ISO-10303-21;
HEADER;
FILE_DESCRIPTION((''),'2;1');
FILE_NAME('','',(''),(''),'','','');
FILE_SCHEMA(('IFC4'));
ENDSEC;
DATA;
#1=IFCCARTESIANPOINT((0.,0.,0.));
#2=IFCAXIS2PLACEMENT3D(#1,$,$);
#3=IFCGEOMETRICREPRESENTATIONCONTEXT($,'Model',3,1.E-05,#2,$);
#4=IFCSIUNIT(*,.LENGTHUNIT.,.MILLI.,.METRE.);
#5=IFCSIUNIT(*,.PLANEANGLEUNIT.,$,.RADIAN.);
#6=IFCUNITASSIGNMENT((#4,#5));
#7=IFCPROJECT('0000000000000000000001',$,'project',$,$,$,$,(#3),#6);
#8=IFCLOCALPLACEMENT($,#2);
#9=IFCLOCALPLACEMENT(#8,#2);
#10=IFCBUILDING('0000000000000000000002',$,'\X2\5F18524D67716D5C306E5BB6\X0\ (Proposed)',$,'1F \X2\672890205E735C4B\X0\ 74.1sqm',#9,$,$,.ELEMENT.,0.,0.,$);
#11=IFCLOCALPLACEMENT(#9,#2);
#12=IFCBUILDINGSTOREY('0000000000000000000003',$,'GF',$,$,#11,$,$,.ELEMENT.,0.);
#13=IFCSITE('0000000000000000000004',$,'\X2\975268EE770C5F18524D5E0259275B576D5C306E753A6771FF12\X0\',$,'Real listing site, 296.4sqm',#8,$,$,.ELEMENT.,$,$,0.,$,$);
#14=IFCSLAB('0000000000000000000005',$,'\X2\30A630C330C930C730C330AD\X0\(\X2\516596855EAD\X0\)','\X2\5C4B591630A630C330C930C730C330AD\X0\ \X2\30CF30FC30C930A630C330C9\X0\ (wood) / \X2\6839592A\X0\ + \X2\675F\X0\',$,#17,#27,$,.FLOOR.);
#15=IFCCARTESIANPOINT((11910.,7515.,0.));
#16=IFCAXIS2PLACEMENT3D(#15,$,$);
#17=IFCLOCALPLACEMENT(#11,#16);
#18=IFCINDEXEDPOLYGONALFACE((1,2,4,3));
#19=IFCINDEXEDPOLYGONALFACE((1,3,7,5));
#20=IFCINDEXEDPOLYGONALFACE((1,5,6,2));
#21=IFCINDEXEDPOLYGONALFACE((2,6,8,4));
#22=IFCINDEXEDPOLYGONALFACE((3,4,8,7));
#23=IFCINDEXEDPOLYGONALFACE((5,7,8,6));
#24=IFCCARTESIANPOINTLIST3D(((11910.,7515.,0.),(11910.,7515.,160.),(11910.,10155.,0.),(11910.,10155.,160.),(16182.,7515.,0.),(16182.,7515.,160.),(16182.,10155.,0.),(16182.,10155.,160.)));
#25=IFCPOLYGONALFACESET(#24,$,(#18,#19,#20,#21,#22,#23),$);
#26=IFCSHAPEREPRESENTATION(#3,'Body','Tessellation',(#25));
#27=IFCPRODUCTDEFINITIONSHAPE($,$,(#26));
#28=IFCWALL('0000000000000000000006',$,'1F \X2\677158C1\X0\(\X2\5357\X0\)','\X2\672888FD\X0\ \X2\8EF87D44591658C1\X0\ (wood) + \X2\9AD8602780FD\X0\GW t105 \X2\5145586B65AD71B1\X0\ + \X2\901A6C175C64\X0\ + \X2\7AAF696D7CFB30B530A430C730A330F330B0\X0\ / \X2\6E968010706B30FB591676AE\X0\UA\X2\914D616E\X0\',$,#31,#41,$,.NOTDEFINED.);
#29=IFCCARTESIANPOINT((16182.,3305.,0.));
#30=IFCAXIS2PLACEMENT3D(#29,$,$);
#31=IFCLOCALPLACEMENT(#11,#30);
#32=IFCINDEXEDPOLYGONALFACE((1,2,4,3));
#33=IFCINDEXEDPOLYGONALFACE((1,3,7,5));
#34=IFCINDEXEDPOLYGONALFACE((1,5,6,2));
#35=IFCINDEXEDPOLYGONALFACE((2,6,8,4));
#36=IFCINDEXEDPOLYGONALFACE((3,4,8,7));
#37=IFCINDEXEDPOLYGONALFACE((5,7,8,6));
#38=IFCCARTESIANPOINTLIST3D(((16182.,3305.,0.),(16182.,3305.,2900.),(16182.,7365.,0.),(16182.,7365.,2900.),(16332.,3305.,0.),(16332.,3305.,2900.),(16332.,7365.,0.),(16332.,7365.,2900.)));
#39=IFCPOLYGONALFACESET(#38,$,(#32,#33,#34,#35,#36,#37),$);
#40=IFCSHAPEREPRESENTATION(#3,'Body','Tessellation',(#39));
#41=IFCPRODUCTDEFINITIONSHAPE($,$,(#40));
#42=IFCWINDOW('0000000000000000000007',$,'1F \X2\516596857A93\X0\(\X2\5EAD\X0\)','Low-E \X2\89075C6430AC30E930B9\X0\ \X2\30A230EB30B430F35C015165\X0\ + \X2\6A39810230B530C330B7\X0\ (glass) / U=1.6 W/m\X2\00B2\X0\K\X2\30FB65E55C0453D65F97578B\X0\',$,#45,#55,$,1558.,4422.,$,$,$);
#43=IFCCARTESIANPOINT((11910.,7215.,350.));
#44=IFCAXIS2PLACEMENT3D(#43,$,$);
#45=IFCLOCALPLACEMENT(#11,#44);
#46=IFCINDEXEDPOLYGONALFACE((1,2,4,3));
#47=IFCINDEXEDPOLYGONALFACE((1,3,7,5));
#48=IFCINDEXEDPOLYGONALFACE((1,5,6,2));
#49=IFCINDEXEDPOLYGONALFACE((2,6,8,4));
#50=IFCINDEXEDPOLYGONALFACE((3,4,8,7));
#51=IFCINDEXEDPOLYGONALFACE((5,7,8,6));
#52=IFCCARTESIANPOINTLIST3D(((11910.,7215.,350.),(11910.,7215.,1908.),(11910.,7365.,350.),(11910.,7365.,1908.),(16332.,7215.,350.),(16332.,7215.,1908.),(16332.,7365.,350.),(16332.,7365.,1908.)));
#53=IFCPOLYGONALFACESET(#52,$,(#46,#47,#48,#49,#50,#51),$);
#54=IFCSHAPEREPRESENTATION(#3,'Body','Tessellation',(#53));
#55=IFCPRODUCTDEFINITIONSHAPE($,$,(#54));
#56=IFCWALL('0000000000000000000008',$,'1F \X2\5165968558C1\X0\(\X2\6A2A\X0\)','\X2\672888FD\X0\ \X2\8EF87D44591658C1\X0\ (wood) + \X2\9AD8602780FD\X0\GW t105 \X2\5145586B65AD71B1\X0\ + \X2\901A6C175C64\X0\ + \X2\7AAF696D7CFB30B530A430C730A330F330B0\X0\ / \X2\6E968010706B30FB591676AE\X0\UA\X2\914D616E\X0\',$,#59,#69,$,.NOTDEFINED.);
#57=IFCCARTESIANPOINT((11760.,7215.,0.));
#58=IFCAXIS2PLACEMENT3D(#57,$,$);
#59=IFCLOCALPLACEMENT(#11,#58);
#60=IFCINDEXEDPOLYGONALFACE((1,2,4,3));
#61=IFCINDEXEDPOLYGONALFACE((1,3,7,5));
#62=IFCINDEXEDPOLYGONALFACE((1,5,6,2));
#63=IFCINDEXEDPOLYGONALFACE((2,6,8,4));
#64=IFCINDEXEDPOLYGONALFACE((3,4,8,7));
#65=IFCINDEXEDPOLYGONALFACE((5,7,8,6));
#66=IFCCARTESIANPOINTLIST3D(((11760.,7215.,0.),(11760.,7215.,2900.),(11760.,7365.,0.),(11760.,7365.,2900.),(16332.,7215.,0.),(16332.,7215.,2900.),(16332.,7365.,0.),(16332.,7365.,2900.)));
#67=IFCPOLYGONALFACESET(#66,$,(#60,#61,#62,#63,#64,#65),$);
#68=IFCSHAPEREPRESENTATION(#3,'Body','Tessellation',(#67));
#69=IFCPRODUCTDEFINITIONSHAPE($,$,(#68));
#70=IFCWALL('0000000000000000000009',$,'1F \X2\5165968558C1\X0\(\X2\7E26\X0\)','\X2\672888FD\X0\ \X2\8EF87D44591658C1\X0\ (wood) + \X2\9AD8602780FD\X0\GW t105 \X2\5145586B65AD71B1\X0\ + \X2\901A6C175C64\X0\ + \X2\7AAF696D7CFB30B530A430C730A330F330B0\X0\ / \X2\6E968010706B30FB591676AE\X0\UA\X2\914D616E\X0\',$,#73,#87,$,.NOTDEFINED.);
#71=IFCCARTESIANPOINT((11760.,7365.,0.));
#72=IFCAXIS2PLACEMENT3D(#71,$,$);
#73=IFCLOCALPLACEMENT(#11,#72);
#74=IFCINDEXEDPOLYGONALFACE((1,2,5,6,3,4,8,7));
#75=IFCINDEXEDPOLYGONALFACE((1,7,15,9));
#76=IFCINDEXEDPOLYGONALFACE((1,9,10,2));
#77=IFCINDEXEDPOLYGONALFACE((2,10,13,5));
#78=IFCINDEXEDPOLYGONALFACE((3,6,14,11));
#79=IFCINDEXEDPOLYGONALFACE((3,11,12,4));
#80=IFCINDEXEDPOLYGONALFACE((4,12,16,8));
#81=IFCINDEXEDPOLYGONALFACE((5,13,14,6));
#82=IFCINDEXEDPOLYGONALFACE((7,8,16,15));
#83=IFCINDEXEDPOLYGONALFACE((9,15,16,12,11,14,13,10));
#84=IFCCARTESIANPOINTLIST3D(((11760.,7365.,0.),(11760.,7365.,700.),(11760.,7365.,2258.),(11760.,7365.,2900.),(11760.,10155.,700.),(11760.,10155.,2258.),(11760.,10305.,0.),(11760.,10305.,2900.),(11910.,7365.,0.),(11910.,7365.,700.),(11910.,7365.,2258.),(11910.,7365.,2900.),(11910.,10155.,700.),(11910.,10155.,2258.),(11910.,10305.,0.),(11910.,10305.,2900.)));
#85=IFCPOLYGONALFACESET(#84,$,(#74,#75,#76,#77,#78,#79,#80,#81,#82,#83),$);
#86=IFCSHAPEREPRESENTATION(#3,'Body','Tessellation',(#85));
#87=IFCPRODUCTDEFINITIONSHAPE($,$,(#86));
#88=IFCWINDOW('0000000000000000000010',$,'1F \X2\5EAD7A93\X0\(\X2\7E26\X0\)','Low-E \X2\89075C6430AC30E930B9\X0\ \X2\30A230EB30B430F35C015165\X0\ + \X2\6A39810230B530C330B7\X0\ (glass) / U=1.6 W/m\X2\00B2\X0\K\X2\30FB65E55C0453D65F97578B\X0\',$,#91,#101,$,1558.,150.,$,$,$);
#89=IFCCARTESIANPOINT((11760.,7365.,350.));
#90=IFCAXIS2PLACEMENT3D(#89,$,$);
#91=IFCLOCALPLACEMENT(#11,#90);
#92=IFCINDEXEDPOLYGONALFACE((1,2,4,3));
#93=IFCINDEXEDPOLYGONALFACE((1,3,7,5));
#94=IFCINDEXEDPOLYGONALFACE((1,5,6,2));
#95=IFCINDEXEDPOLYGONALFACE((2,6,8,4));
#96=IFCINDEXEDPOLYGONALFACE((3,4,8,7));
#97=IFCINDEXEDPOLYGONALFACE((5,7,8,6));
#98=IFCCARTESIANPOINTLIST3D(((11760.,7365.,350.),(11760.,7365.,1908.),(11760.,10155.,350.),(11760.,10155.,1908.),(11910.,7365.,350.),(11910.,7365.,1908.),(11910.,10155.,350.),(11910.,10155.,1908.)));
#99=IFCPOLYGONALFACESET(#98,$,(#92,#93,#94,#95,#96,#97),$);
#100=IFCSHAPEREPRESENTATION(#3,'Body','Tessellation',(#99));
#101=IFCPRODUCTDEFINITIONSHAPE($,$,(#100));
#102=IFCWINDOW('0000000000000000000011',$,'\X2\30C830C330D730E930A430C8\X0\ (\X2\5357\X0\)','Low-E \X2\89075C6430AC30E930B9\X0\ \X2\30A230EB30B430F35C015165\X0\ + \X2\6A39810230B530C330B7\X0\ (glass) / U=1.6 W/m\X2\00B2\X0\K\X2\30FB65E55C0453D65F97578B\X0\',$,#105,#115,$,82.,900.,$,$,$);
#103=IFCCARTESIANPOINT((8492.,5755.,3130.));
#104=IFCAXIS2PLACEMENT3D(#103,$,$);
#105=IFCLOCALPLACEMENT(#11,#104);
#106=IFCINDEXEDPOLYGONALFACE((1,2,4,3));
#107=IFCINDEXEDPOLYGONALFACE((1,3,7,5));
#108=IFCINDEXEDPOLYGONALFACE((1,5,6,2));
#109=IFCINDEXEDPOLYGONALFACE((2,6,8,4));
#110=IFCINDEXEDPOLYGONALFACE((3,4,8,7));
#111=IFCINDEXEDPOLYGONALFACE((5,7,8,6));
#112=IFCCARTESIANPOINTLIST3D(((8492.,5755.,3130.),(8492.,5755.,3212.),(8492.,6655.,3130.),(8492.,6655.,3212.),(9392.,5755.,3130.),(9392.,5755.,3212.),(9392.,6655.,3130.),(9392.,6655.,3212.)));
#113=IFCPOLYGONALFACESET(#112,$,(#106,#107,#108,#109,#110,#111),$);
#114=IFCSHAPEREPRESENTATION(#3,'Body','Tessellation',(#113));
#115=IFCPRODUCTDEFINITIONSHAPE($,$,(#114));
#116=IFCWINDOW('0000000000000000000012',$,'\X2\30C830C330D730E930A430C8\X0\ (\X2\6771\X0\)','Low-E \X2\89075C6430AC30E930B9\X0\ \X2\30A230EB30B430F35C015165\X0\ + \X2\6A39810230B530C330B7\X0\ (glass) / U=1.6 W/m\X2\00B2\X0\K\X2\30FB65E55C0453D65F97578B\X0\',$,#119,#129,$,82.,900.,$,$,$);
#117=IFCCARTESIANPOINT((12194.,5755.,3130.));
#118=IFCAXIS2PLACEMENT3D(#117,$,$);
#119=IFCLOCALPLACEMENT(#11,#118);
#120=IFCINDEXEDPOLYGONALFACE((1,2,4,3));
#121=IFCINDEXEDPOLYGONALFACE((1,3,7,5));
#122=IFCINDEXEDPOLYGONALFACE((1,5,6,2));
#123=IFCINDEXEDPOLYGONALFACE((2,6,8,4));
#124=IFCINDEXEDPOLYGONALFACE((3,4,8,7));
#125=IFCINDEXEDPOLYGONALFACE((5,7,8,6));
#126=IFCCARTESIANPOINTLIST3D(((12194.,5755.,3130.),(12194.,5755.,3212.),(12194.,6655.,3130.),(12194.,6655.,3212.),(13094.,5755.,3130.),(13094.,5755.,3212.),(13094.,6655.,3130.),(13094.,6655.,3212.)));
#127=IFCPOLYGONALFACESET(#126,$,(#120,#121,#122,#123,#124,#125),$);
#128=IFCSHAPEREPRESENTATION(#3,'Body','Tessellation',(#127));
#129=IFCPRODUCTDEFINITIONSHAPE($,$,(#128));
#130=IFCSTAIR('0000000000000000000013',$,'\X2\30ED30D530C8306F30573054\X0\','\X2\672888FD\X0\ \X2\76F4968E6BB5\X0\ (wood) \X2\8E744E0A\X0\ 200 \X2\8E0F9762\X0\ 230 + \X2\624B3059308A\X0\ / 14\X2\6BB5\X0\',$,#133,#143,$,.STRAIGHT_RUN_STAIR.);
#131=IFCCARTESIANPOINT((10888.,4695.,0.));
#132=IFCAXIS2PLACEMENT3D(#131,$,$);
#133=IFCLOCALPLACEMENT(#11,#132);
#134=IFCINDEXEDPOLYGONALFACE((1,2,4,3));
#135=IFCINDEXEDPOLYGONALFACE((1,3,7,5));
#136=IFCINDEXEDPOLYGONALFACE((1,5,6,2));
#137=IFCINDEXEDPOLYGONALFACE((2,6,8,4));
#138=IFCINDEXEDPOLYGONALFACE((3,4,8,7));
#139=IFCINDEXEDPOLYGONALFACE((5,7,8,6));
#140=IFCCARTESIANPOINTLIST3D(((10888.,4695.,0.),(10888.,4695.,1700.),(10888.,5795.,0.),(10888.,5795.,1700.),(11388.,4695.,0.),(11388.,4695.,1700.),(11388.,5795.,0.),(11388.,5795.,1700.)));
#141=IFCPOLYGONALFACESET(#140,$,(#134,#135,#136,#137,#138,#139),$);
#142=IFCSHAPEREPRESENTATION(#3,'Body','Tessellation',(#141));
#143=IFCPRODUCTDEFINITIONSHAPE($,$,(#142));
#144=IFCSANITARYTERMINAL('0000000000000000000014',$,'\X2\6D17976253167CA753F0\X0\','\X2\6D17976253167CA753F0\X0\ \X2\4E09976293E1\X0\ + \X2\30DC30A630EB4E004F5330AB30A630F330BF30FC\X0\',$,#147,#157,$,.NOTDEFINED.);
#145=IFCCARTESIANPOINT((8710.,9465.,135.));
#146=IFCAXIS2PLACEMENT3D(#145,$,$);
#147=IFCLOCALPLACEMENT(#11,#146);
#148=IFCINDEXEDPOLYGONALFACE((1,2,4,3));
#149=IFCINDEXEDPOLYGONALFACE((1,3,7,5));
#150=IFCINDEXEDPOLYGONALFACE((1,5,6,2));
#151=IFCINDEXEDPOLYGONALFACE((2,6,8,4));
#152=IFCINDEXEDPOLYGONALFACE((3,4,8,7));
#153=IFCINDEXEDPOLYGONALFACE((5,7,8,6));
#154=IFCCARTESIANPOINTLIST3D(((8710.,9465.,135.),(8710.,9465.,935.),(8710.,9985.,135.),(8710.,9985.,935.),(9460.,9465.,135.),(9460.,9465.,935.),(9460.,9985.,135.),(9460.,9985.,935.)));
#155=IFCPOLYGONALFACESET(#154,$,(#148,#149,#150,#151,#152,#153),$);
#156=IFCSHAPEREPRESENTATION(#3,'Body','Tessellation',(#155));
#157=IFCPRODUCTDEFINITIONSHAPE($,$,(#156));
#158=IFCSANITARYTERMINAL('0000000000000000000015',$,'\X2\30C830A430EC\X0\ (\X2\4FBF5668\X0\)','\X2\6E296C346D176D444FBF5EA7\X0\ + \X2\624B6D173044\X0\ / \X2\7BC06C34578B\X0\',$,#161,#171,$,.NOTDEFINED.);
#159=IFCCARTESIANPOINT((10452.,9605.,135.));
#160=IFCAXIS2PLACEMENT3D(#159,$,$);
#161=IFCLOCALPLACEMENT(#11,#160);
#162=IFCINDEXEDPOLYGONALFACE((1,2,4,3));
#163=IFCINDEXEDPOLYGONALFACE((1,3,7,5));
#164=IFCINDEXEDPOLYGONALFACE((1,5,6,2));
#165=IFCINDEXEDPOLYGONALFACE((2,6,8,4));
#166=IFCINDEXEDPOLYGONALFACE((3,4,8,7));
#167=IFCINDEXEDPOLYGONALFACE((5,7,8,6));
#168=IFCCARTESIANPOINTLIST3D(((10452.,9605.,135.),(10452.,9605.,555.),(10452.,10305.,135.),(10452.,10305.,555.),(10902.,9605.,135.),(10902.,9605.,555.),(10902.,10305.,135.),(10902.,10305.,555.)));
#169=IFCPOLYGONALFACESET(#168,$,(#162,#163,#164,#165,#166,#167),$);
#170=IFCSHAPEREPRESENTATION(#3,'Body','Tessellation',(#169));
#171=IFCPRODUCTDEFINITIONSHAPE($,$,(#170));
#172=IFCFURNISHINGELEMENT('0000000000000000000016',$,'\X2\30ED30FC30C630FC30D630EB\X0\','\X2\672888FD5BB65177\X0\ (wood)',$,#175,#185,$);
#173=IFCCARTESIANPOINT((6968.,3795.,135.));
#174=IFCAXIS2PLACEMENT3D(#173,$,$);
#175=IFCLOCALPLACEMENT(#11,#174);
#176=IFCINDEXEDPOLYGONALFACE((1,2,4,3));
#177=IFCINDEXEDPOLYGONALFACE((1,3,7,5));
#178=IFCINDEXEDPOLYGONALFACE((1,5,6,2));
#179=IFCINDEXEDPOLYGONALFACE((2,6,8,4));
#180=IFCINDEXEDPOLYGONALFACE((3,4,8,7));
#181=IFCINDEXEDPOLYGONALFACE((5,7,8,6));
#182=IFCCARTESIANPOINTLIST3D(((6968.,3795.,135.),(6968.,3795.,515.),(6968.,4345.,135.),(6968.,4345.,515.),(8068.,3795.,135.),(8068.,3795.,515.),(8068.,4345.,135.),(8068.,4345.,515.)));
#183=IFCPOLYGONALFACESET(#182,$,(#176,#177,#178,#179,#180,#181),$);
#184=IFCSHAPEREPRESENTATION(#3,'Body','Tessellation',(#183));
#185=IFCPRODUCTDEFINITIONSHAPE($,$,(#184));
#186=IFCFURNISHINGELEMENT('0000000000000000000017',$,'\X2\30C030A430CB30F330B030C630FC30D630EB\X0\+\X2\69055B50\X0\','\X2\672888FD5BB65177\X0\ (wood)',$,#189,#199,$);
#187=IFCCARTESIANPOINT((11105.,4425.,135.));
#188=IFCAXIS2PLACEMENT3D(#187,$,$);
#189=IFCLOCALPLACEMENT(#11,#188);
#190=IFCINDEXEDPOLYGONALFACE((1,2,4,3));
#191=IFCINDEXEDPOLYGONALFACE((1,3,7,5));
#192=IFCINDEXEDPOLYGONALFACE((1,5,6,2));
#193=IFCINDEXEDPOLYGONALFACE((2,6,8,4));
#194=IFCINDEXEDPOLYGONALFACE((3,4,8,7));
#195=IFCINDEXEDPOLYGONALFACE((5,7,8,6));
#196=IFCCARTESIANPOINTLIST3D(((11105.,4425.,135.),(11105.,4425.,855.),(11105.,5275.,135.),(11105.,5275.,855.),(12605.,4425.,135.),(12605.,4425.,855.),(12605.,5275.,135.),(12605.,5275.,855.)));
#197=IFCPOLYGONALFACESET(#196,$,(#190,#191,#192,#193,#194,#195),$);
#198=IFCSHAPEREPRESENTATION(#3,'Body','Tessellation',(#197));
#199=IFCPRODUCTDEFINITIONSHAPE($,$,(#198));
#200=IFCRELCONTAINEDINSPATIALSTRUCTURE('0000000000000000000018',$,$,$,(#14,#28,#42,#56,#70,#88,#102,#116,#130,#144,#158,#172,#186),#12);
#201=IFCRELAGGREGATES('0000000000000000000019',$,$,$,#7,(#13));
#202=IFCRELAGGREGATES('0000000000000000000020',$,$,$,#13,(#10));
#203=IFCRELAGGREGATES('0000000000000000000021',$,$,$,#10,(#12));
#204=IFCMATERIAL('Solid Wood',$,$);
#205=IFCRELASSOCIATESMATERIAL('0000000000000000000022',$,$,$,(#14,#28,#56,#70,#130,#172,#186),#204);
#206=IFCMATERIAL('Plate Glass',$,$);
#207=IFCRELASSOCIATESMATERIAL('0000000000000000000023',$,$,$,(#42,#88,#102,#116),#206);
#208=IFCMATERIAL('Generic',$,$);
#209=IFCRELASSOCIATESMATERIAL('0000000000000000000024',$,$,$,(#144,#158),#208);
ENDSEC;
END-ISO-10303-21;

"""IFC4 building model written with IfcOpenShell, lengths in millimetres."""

from ifc_helpers import new_model, si_unit, frame, frame_2d, origin, place, context, project, spatial, rectangle, extrude, material, element, fill, save


model = new_model("IFC4")

# Units and contexts
model_context = context("Model", 3, precision=1e-05, world=origin())
ifc_project = project(units=[si_unit("LENGTHUNIT", "METRE", prefix="MILLI"), si_unit("PLANEANGLEUNIT", "RADIAN")], contexts=[model_context])

# Site, building, storey
site_placement = place(None, origin())
site = spatial("IfcSite", under=ifc_project, at=site_placement, Name="青森県弘前市大字浜の町東２", ObjectType="Real listing site, 296.4sqm", CompositionType="ELEMENT", RefElevation=0.0)
building_placement = place(site_placement, origin())
building = spatial("IfcBuilding", under=site, at=building_placement, Name="弘前東浜の家 (Proposed)", ObjectType="1F 木造平屋 74.1sqm", CompositionType="ELEMENT", ElevationOfRefHeight=0.0, ElevationOfTerrain=0.0)
storey_placement = place(building_placement, origin())
storey = spatial("IfcBuildingStorey", under=building, at=storey_placement, Name="GF", CompositionType="ELEMENT", Elevation=0.0)

# Slab
ifc_material_1 = material(Name="Solid Wood")
slab_placement = place(storey_placement, frame((11910.0, 7515.0, 0.0)))
element("IfcSlab", 1, at=slab_placement, inside=storey, material=ifc_material_1, Name="ウッドデッキ(入隅庭)", Description="屋外ウッドデッキ ハードウッド (wood) / 根太 + 束", PredefinedType="FLOOR", context=model_context, shape_type="SweptSolid", body=[
    extrude(rectangle(XDim=4272.0, YDim=2640.0, at=frame_2d((2136.0, 1320.0))), frame((11910.0, 7515.0, 0.0)), (0.0, 0.0, 1.0), 160.0),
])

# Wall, opening, window
wall_1_placement = place(storey_placement, frame((16182.0, 3305.0, 0.0)))
wall_1 = element("IfcWall", 2, at=wall_1_placement, inside=storey, material=ifc_material_1, Name="1F 東壁(南)", Description="木製 軸組外壁 (wood) + 高性能GW t105 充填断熱 + 通気層 + 窯業系サイディング / 準耐火・外皮UA配慮", PredefinedType="NOTDEFINED", context=model_context, shape_type="SweptSolid", body=[
    extrude(rectangle(XDim=150.0, YDim=4060.0, at=frame_2d((75.0, 2030.0))), frame((16182.0, 3305.0, 0.0)), (0.0, 0.0, 1.0), 2900.0),
])
opening_1_placement = place(storey_placement, frame((11910.0, 7215.0, 350.0)))
opening_1 = element("IfcOpeningElement", 3, at=opening_1_placement, cuts=wall_1, PredefinedType="NOTDEFINED", context=model_context, shape_type="SweptSolid", body=[
    extrude(rectangle(XDim=4422.0, YDim=150.0, at=frame_2d((2211.0, 75.0))), frame((11910.0, 7215.0, 350.0)), (0.0, 0.0, 1.0), 1558.0),
])
ifc_material_2 = material(Name="Plate Glass")
window_1_placement = place(storey_placement, frame((11910.0, 7215.0, 350.0)))
window_1 = element("IfcWindow", 4, at=window_1_placement, inside=storey, material=ifc_material_2, Name="1F 入隅窓(庭)", Description="Low-E 複層ガラス アルゴン封入 + 樹脂サッシ (glass) / U=1.6 W/m²K・日射取得型", OverallHeight=1558.0, OverallWidth=4422.0, context=model_context, shape_type="SweptSolid", body=[
    extrude(rectangle(XDim=4422.0, YDim=150.0, at=frame_2d((2211.0, 75.0))), frame((11910.0, 7215.0, 350.0)), (0.0, 0.0, 1.0), 1558.0),
])
fill(opening_1, window_1)

# Wall
wall_2_placement = place(storey_placement, frame((11760.0, 7215.0, 0.0)))
element("IfcWall", 5, at=wall_2_placement, inside=storey, material=ifc_material_1, Name="1F 入隅壁(横)", Description="木製 軸組外壁 (wood) + 高性能GW t105 充填断熱 + 通気層 + 窯業系サイディング / 準耐火・外皮UA配慮", PredefinedType="NOTDEFINED", context=model_context, shape_type="SweptSolid", body=[
    extrude(rectangle(XDim=4572.0, YDim=150.0, at=frame_2d((2286.0, 75.0))), frame((11760.0, 7215.0, 0.0)), (0.0, 0.0, 1.0), 2900.0),
])

# Wall, opening, window
wall_3_placement = place(storey_placement, frame((11760.0, 7365.0, 0.0)))
wall_3 = element("IfcWall", 6, at=wall_3_placement, inside=storey, material=ifc_material_1, Name="1F 入隅壁(縦)", Description="木製 軸組外壁 (wood) + 高性能GW t105 充填断熱 + 通気層 + 窯業系サイディング / 準耐火・外皮UA配慮", PredefinedType="NOTDEFINED", context=model_context, shape_type="SweptSolid", body=[
    extrude(rectangle(XDim=150.0, YDim=2940.0, at=frame_2d((75.0, 1470.0))), frame((11760.0, 7365.0, 0.0)), (0.0, 0.0, 1.0), 2900.0),
])
opening_2_placement = place(storey_placement, frame((11760.0, 7365.0, 350.0)))
opening_2 = element("IfcOpeningElement", 7, at=opening_2_placement, cuts=wall_3, PredefinedType="NOTDEFINED", context=model_context, shape_type="SweptSolid", body=[
    extrude(rectangle(XDim=150.0, YDim=2790.0, at=frame_2d((75.0, 1395.0))), frame((11760.0, 7365.0, 350.0)), (0.0, 0.0, 1.0), 1558.0),
])
window_2_placement = place(storey_placement, frame((11760.0, 7365.0, 350.0)))
window_2 = element("IfcWindow", 8, at=window_2_placement, inside=storey, material=ifc_material_2, Name="1F 庭窓(縦)", Description="Low-E 複層ガラス アルゴン封入 + 樹脂サッシ (glass) / U=1.6 W/m²K・日射取得型", OverallHeight=1558.0, OverallWidth=150.0, context=model_context, shape_type="SweptSolid", body=[
    extrude(rectangle(XDim=150.0, YDim=2790.0, at=frame_2d((75.0, 1395.0))), frame((11760.0, 7365.0, 350.0)), (0.0, 0.0, 1.0), 1558.0),
])
fill(opening_2, window_2)

# Windows
window_3_placement = place(storey_placement, frame((8492.0, 5755.0, 3130.0)))
element("IfcWindow", 9, at=window_3_placement, inside=storey, material=ifc_material_2, Name="トップライト (南)", Description="Low-E 複層ガラス アルゴン封入 + 樹脂サッシ (glass) / U=1.6 W/m²K・日射取得型", OverallHeight=82.0, OverallWidth=900.0, context=model_context, shape_type="SweptSolid", body=[
    extrude(rectangle(XDim=900.0, YDim=900.0, at=frame_2d((450.0, 450.0))), frame((8492.0, 5755.0, 3130.0)), (0.0, 0.0, 1.0), 82.0),
])
window_4_placement = place(storey_placement, frame((12194.0, 5755.0, 3130.0)))
element("IfcWindow", 10, at=window_4_placement, inside=storey, material=ifc_material_2, Name="トップライト (東)", Description="Low-E 複層ガラス アルゴン封入 + 樹脂サッシ (glass) / U=1.6 W/m²K・日射取得型", OverallHeight=82.0, OverallWidth=900.0, context=model_context, shape_type="SweptSolid", body=[
    extrude(rectangle(XDim=900.0, YDim=900.0, at=frame_2d((450.0, 450.0))), frame((12194.0, 5755.0, 3130.0)), (0.0, 0.0, 1.0), 82.0),
])

# Stair
stair_placement = place(storey_placement, frame((10888.0, 4695.0, 0.0)))
element("IfcStair", 11, at=stair_placement, inside=storey, material=ifc_material_1, Name="ロフトはしご", Description="木製 直階段 (wood) 蹴上 200 踏面 230 + 手すり / 14段", PredefinedType="STRAIGHT_RUN_STAIR", context=model_context, shape_type="SweptSolid", body=[
    extrude(rectangle(XDim=500.0, YDim=1100.0, at=frame_2d((250.0, 550.0))), frame((10888.0, 4695.0, 0.0)), (0.0, 0.0, 1.0), 1700.0),
])

# Sanitary terminals
ifc_material_3 = material(Name="Generic")
sanitary_terminal_1_placement = place(storey_placement, frame((8710.0, 9465.0, 135.0)))
element("IfcSanitaryTerminal", 12, at=sanitary_terminal_1_placement, inside=storey, material=ifc_material_3, Name="洗面化粧台", Description="洗面化粧台 三面鏡 + ボウル一体カウンター", PredefinedType="NOTDEFINED", context=model_context, shape_type="SweptSolid", body=[
    extrude(rectangle(XDim=750.0, YDim=520.0, at=frame_2d((375.0, 260.0))), frame((8710.0, 9465.0, 135.0)), (0.0, 0.0, 1.0), 800.0),
])
sanitary_terminal_2_placement = place(storey_placement, frame((10452.0, 9605.0, 135.0)))
element("IfcSanitaryTerminal", 13, at=sanitary_terminal_2_placement, inside=storey, material=ifc_material_3, Name="トイレ (便器)", Description="温水洗浄便座 + 手洗い / 節水型", PredefinedType="NOTDEFINED", context=model_context, shape_type="SweptSolid", body=[
    extrude(rectangle(XDim=450.0, YDim=700.0, at=frame_2d((225.0, 350.0))), frame((10452.0, 9605.0, 135.0)), (0.0, 0.0, 1.0), 420.0),
])

# Furnishing elements
furnishing_1_placement = place(storey_placement, frame((6968.0, 3795.0, 135.0)))
element("IfcFurnishingElement", 14, at=furnishing_1_placement, inside=storey, material=ifc_material_1, Name="ローテーブル", Description="木製家具 (wood)", context=model_context, shape_type="SweptSolid", body=[
    extrude(rectangle(XDim=1100.0, YDim=550.0, at=frame_2d((550.0, 275.0))), frame((6968.0, 3795.0, 135.0)), (0.0, 0.0, 1.0), 380.0),
])
furnishing_2_placement = place(storey_placement, frame((11105.0, 4425.0, 135.0)))
element("IfcFurnishingElement", 15, at=furnishing_2_placement, inside=storey, material=ifc_material_1, Name="ダイニングテーブル+椅子", Description="木製家具 (wood)", context=model_context, shape_type="SweptSolid", body=[
    extrude(rectangle(XDim=1500.0, YDim=850.0, at=frame_2d((750.0, 425.0))), frame((11105.0, 4425.0, 135.0)), (0.0, 0.0, 1.0), 720.0),
])

save(model, "model.ifc")
